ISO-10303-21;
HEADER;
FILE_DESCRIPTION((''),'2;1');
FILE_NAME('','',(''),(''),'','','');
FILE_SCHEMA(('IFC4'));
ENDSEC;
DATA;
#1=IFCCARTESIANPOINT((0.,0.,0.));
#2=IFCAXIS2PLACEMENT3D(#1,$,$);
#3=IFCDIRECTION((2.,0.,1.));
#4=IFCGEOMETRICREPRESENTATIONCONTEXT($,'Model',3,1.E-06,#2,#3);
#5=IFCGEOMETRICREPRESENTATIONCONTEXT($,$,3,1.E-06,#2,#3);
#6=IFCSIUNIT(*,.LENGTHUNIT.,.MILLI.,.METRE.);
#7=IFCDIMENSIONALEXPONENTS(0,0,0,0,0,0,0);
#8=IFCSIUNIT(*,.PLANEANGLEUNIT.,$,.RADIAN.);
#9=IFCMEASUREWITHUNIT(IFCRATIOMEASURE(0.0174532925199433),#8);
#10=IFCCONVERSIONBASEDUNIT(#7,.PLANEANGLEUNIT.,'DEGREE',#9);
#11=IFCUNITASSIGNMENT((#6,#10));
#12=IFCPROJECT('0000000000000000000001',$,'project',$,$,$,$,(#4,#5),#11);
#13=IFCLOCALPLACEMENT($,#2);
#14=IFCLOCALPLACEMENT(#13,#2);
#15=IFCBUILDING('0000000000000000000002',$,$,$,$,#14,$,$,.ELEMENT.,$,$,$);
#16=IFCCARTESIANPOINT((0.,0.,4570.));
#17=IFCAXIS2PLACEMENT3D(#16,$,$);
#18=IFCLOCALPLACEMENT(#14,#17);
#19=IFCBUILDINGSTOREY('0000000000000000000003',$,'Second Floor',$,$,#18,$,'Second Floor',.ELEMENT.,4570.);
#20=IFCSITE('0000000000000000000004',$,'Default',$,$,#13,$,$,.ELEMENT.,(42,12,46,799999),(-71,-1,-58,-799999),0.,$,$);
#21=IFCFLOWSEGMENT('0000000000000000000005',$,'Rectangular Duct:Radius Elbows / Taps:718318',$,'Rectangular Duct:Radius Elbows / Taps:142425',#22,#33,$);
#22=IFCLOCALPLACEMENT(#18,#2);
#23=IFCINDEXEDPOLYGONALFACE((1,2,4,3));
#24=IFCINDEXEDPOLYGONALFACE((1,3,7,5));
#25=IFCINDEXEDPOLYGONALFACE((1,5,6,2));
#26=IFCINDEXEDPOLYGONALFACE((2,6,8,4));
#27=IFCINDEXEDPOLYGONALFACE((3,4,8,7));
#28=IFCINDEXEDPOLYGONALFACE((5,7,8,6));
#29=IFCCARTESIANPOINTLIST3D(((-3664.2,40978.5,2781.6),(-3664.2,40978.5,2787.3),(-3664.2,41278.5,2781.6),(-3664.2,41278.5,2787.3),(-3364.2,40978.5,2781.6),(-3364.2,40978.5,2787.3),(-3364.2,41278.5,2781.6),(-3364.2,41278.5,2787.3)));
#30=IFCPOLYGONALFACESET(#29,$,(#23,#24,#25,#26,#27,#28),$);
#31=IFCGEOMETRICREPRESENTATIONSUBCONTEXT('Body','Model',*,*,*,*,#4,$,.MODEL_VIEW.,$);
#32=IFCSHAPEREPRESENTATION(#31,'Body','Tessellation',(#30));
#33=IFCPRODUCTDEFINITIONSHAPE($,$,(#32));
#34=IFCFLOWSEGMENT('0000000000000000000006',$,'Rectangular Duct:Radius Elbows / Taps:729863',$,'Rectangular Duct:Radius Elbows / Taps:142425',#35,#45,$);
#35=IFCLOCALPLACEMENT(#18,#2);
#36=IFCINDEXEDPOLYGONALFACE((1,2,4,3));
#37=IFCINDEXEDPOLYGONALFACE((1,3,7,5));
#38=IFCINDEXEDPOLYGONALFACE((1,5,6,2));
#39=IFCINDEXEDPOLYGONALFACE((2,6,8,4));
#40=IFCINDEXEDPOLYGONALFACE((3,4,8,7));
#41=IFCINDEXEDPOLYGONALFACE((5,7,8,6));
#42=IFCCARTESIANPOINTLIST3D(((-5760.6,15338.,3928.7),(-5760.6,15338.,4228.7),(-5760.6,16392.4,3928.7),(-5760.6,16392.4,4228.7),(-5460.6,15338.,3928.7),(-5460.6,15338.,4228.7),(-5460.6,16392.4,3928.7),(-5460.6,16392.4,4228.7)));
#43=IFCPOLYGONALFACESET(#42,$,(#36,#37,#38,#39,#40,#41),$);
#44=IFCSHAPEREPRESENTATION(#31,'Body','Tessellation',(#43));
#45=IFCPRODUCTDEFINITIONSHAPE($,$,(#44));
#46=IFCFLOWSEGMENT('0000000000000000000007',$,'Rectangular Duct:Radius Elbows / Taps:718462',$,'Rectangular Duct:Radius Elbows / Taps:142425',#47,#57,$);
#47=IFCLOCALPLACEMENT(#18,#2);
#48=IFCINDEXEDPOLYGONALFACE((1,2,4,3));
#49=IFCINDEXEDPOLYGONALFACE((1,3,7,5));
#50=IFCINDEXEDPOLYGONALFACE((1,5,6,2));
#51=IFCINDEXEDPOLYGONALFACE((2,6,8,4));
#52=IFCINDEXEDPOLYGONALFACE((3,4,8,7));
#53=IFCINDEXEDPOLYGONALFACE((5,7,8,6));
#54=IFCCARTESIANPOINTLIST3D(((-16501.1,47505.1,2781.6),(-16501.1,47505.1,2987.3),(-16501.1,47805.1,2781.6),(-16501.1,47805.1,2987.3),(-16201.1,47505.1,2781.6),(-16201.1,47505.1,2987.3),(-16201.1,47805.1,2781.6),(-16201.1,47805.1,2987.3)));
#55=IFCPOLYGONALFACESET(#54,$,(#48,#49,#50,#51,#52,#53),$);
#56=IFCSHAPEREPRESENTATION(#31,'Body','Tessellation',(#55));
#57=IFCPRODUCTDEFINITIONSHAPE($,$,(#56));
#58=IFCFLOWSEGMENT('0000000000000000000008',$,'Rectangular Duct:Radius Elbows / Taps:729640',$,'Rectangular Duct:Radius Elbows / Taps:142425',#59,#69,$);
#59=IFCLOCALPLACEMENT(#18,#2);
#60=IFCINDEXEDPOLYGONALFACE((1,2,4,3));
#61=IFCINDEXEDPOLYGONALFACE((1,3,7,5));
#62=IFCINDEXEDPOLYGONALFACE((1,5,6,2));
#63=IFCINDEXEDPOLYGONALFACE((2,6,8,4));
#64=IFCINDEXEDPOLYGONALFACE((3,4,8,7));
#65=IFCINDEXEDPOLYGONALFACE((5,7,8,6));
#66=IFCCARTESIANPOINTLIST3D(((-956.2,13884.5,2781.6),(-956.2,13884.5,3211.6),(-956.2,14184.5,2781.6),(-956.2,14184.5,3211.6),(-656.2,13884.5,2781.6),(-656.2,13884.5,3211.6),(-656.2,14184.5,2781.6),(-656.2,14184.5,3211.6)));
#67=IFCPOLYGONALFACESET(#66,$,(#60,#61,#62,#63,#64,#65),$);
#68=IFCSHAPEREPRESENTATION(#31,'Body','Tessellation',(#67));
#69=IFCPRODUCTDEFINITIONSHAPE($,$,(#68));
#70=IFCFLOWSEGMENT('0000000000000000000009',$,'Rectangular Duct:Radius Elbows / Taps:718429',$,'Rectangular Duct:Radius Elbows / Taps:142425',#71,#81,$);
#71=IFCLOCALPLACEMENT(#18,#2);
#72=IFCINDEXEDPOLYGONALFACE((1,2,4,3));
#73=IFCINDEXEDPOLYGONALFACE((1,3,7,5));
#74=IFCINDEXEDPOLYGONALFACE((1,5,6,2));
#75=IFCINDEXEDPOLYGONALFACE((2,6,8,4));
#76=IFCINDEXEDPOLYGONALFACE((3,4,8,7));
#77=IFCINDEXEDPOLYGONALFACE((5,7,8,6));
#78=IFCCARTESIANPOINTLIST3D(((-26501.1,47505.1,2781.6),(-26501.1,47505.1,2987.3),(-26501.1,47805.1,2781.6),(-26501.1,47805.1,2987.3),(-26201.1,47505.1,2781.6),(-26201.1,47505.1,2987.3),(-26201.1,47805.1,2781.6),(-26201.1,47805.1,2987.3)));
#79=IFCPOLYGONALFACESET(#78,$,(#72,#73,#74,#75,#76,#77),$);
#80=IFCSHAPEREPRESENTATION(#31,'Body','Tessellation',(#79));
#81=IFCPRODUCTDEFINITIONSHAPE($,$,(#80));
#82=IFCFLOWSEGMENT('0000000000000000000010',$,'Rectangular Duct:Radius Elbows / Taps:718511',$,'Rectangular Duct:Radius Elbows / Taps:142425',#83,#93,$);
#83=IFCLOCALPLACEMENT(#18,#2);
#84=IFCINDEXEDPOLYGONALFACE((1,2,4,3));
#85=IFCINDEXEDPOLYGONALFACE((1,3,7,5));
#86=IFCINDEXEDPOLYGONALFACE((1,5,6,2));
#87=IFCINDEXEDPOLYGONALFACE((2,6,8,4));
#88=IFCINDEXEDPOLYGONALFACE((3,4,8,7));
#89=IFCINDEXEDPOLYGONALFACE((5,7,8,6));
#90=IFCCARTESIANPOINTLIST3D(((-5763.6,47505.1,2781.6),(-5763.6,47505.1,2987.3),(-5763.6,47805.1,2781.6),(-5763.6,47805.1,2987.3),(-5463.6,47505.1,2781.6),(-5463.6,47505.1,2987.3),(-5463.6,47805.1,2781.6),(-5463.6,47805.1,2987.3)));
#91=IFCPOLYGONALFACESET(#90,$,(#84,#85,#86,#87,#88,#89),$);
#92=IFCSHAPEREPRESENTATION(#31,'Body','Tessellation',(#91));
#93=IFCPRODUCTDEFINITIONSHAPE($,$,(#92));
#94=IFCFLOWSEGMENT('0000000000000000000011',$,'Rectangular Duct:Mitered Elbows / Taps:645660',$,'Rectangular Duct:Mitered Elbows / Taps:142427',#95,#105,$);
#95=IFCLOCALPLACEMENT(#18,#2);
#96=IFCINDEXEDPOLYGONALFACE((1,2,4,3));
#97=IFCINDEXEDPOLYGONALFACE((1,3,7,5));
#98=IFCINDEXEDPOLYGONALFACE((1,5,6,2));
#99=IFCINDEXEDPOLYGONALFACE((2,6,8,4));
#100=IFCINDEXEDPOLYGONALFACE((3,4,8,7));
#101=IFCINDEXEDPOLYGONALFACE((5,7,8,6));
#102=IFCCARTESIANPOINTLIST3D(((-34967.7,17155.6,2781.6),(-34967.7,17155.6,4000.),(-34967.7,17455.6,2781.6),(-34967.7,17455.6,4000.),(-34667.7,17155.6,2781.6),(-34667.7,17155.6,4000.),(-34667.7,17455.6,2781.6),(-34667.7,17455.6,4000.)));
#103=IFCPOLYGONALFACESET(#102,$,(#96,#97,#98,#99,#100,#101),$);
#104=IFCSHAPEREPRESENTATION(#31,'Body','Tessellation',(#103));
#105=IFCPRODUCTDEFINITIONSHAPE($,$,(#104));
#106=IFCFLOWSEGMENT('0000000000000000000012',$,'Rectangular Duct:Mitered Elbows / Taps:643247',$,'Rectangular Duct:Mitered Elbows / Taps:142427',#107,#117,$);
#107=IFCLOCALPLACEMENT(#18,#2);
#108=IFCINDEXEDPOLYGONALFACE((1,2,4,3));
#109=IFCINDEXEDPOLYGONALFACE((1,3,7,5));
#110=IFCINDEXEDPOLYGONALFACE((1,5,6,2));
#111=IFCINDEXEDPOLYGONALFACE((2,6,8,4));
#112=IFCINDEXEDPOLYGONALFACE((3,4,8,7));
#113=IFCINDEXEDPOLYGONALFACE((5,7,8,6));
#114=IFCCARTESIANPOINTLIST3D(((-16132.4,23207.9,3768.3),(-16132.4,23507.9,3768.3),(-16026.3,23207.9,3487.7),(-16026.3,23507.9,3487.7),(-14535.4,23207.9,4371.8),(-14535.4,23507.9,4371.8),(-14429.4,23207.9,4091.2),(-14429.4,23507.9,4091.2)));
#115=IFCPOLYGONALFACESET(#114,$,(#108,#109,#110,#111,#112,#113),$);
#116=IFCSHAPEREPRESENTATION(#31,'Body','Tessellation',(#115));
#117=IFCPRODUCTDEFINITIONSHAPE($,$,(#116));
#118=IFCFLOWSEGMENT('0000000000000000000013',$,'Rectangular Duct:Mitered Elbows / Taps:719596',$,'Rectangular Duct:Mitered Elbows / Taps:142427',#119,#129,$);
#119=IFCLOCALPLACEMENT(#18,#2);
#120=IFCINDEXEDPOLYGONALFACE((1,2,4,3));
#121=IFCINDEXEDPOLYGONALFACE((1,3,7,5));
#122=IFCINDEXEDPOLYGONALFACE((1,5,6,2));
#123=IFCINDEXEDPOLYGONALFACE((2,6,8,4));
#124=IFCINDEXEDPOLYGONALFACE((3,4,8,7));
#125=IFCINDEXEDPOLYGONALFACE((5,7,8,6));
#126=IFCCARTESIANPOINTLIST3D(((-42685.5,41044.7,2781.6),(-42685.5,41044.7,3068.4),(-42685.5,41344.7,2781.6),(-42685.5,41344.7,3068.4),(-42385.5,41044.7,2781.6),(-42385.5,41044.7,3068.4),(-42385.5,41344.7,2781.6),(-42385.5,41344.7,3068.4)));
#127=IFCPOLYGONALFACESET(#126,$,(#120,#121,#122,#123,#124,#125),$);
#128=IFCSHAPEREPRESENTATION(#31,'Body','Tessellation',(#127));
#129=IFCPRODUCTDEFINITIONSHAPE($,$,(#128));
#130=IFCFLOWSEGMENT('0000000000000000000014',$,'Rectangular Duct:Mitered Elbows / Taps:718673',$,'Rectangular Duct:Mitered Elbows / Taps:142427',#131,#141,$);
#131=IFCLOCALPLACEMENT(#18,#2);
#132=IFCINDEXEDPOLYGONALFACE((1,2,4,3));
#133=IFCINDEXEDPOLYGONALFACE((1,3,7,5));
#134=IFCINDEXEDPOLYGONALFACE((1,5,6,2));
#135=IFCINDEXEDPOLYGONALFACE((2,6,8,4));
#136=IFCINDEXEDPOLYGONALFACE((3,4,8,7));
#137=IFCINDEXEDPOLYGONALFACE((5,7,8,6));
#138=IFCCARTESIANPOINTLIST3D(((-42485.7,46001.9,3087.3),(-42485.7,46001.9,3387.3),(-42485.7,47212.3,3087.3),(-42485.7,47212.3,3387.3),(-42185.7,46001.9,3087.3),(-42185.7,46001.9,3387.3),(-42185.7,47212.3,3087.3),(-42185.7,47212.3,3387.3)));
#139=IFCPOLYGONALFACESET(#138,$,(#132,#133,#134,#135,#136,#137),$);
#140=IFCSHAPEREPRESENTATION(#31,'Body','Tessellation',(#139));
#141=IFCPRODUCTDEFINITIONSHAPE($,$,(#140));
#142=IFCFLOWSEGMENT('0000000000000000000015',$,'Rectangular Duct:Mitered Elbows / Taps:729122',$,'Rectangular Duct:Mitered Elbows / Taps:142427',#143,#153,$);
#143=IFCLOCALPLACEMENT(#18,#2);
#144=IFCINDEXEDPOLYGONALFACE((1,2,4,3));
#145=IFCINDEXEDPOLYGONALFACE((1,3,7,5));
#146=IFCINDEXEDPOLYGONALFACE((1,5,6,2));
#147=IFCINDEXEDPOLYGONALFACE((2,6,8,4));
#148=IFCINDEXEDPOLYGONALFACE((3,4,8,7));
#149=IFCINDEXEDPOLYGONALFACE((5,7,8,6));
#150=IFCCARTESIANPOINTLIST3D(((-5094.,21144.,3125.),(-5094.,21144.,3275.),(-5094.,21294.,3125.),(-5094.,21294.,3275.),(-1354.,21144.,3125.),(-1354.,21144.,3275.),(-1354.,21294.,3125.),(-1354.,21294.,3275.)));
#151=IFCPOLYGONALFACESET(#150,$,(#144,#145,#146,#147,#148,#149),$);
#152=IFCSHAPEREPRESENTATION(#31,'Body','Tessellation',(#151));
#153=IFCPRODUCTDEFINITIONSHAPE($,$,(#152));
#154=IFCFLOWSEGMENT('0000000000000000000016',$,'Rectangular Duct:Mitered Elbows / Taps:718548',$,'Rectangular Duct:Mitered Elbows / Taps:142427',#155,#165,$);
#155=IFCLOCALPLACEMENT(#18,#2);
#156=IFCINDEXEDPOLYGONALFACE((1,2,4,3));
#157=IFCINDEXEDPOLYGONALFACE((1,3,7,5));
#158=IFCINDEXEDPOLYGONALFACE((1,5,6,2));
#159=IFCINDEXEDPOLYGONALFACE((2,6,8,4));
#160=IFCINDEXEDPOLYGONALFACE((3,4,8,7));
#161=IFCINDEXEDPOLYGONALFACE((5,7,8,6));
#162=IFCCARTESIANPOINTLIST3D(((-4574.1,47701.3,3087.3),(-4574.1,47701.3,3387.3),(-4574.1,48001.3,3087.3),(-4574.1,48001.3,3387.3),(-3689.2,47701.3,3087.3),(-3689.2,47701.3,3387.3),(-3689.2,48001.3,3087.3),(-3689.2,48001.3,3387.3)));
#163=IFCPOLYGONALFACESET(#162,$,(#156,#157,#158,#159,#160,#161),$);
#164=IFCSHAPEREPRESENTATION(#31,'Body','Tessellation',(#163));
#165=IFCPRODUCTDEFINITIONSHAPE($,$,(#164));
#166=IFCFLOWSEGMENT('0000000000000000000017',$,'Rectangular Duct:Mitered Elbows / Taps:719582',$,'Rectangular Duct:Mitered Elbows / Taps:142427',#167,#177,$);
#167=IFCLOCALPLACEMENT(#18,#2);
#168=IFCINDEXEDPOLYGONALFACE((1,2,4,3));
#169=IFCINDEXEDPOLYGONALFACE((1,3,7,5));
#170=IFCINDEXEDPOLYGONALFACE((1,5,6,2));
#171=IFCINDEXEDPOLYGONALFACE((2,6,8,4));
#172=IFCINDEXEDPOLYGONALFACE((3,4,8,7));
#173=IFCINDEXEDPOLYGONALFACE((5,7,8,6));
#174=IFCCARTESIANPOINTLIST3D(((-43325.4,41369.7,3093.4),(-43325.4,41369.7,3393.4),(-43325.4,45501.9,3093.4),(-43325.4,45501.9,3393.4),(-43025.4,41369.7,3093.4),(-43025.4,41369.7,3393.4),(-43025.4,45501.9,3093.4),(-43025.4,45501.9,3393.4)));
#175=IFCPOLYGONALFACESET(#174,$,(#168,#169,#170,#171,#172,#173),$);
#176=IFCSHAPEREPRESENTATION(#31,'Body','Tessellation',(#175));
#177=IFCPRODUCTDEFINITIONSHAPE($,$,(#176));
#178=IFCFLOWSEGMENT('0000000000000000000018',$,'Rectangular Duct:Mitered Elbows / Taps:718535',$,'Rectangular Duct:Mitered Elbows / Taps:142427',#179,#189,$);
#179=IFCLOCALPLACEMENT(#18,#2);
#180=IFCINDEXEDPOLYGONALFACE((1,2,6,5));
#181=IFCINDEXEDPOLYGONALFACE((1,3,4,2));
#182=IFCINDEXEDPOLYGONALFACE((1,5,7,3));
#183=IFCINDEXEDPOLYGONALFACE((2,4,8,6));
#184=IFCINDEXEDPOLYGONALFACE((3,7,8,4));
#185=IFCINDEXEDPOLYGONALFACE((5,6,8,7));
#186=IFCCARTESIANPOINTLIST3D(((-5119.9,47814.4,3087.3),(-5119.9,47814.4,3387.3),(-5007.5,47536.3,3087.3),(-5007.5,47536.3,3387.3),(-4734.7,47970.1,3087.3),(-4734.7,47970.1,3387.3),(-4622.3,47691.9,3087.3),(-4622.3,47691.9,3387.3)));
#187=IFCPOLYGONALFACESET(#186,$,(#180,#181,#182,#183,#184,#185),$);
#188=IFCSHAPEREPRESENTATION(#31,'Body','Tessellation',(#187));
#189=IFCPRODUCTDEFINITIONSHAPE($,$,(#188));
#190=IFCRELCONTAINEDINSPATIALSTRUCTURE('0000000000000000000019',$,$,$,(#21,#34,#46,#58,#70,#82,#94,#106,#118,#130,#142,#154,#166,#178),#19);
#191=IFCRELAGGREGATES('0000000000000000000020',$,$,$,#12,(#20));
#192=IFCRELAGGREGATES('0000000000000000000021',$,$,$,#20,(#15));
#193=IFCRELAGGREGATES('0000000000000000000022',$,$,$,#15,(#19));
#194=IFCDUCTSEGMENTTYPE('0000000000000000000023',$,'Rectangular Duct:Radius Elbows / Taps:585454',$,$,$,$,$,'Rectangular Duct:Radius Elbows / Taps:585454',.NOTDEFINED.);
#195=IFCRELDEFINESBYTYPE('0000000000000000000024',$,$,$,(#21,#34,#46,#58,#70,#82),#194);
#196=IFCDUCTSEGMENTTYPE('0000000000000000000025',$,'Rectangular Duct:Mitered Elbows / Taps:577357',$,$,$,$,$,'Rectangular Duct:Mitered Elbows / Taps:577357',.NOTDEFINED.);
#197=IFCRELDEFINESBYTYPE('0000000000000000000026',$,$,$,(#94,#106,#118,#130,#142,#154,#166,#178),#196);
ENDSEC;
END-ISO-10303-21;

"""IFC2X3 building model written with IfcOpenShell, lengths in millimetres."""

from ifc_helpers import new_model, entity, si_unit, converted_unit, direction, frame, frame_2d, origin, origin_2d_with_axis, place, context, subcontext, project, spatial, rectangle, extrude, type_object, element, save


model = new_model("IFC2X3")

# Units and contexts
model_context = context("Model", 3, precision=1e-06, world=origin(), true_north=direction((2.0, 0.0, 1.0)))
context_of_model = context(None, 3, precision=1e-06, world=origin(), true_north=direction((2.0, 0.0, 1.0)))
body_context = subcontext(model_context, "Body", "Model", "MODEL_VIEW")
ifc_project = project(units=[si_unit("LENGTHUNIT", "METRE", prefix="MILLI"), converted_unit("PLANEANGLEUNIT", "DEGREE", entity("IfcRatioMeasure", 0.0174532925199433), si_unit("PLANEANGLEUNIT", "RADIAN"), dimensions=[0, 0, 0, 0, 0, 0, 0])], contexts=[model_context, context_of_model])

# Site, building, storey
site_placement = place(None, origin())
site = spatial("IfcSite", under=ifc_project, at=site_placement, Name="Default", CompositionType="ELEMENT", RefLatitude=(42, 12, 46, 799999), RefLongitude=(-71, -1, -58, -799999), RefElevation=0.0)
building_placement = place(site_placement, origin())
building = spatial("IfcBuilding", under=site, at=building_placement, CompositionType="ELEMENT")
storey_placement = place(building_placement, frame((0.0, 0.0, 4570.0)))
storey = spatial("IfcBuildingStorey", under=building, at=storey_placement, Name="Second Floor", LongName="Second Floor", CompositionType="ELEMENT", Elevation=4570.0)

# Flow segments
duct_segment_type_1 = type_object("IfcDuctSegmentType", Name="Rectangular Duct:Radius Elbows / Taps:585454", ElementType="Rectangular Duct:Radius Elbows / Taps:585454", PredefinedType="NOTDEFINED")
flow_segment_1_placement = place(storey_placement, origin())
element("IfcFlowSegment", 1, at=flow_segment_1_placement, inside=storey, type_object=duct_segment_type_1, Name="Rectangular Duct:Radius Elbows / Taps:718318", ObjectType="Rectangular Duct:Radius Elbows / Taps:142425", context=body_context, shape_type="SweptSolid", body=[
    extrude(rectangle(XDim=300.0, YDim=300.0, at=origin_2d_with_axis()), frame((-3514.2, 41128.5, 2781.6)), (0.0, 0.0, 1.0), 5.7),
])
flow_segment_2_placement = place(storey_placement, origin())
element("IfcFlowSegment", 2, at=flow_segment_2_placement, inside=storey, type_object=duct_segment_type_1, Name="Rectangular Duct:Radius Elbows / Taps:729863", ObjectType="Rectangular Duct:Radius Elbows / Taps:142425", context=body_context, shape_type="SweptSolid", body=[
    extrude(rectangle(XDim=1054.5, YDim=300.0, at=frame_2d((0.0, 0.0), x_axis=(1.0, 0.0))), frame((-5610.6, 15865.2, 3928.7), z_axis=(0.0, 0.0, 1.0), x_axis=(0.0, 1.0, 0.0)), (0.0, 0.0, 1.0), 300.0),
])
flow_segment_3_placement = place(storey_placement, origin())
element("IfcFlowSegment", 3, at=flow_segment_3_placement, inside=storey, type_object=duct_segment_type_1, Name="Rectangular Duct:Radius Elbows / Taps:718462", ObjectType="Rectangular Duct:Radius Elbows / Taps:142425", context=body_context, shape_type="SweptSolid", body=[
    extrude(rectangle(XDim=300.0, YDim=300.0, at=origin_2d_with_axis()), frame((-16351.1, 47655.1, 2781.6), z_axis=(0.0, 0.0, 1.0), x_axis=(-1.0, 0.0, 0.0)), (0.0, 0.0, 1.0), 205.7),
])
flow_segment_4_placement = place(storey_placement, origin())
element("IfcFlowSegment", 4, at=flow_segment_4_placement, inside=storey, type_object=duct_segment_type_1, Name="Rectangular Duct:Radius Elbows / Taps:729640", ObjectType="Rectangular Duct:Radius Elbows / Taps:142425", context=body_context, shape_type="SweptSolid", body=[
    extrude(rectangle(XDim=300.0, YDim=300.0, at=frame_2d((0.0, 0.0), x_axis=(1.0, 0.0))), frame((-806.2, 14034.5, 2781.6), z_axis=(0.0, 0.0, 1.0), x_axis=(0.0, -1.0, 0.0)), (0.0, 0.0, 1.0), 430.0),
])
flow_segment_5_placement = place(storey_placement, origin())
element("IfcFlowSegment", 5, at=flow_segment_5_placement, inside=storey, type_object=duct_segment_type_1, Name="Rectangular Duct:Radius Elbows / Taps:718429", ObjectType="Rectangular Duct:Radius Elbows / Taps:142425", context=body_context, shape_type="SweptSolid", body=[
    extrude(rectangle(XDim=300.0, YDim=300.0, at=origin_2d_with_axis()), frame((-26351.1, 47655.1, 2781.6), z_axis=(0.0, 0.0, 1.0), x_axis=(-1.0, 0.0, 0.0)), (0.0, 0.0, 1.0), 205.7),
])
flow_segment_6_placement = place(storey_placement, origin())
element("IfcFlowSegment", 6, at=flow_segment_6_placement, inside=storey, type_object=duct_segment_type_1, Name="Rectangular Duct:Radius Elbows / Taps:718511", ObjectType="Rectangular Duct:Radius Elbows / Taps:142425", context=body_context, shape_type="SweptSolid", body=[
    extrude(rectangle(XDim=300.0, YDim=300.0, at=frame_2d((0.0, 0.0), x_axis=(1.0, 0.0))), frame((-5613.6, 47655.1, 2781.6), z_axis=(0.0, 0.0, 1.0), x_axis=(-1.0, 0.0, 0.0)), (0.0, 0.0, 1.0), 205.7),
])
duct_segment_type_2 = type_object("IfcDuctSegmentType", Name="Rectangular Duct:Mitered Elbows / Taps:577357", ElementType="Rectangular Duct:Mitered Elbows / Taps:577357", PredefinedType="NOTDEFINED")
flow_segment_7_placement = place(storey_placement, origin())
element("IfcFlowSegment", 7, at=flow_segment_7_placement, inside=storey, type_object=duct_segment_type_2, Name="Rectangular Duct:Mitered Elbows / Taps:645660", ObjectType="Rectangular Duct:Mitered Elbows / Taps:142427", context=body_context, shape_type="SweptSolid", body=[
    extrude(rectangle(XDim=300.0, YDim=300.0, at=frame_2d((0.0, 0.0), x_axis=(1.0, 0.0))), frame((-34817.7, 17305.6, 2781.6), z_axis=(0.0, 0.0, 1.0), x_axis=(-1.0, 0.0, 0.0)), (0.0, 0.0, 1.0), 1218.4),
])
flow_segment_8_placement = place(storey_placement, origin())
element("IfcFlowSegment", 8, at=flow_segment_8_placement, inside=storey, type_object=duct_segment_type_2, Name="Rectangular Duct:Mitered Elbows / Taps:643247", ObjectType="Rectangular Duct:Mitered Elbows / Taps:142427", context=body_context, shape_type="SweptSolid", body=[
    extrude(rectangle(XDim=300.0, YDim=300.0, at=frame_2d((0.0, 0.0), x_axis=(1.0, 0.0))), frame((-16079.4, 23357.9, 3628.0), z_axis=(0.935442, 0.0, 0.353481), x_axis=(-0.353481, 0.0, 0.935442)), (0.0, 0.0, 1.0), 1707.2),
])
flow_segment_9_placement = place(storey_placement, origin())
element("IfcFlowSegment", 9, at=flow_segment_9_placement, inside=storey, type_object=duct_segment_type_2, Name="Rectangular Duct:Mitered Elbows / Taps:719596", ObjectType="Rectangular Duct:Mitered Elbows / Taps:142427", context=body_context, shape_type="SweptSolid", body=[
    extrude(rectangle(XDim=300.0, YDim=300.0, at=origin_2d_with_axis()), frame((-42535.5, 41194.7, 2781.6)), (0.0, 0.0, 1.0), 286.8),
])
flow_segment_10_placement = place(storey_placement, origin())
element("IfcFlowSegment", 10, at=flow_segment_10_placement, inside=storey, type_object=duct_segment_type_2, Name="Rectangular Duct:Mitered Elbows / Taps:718673", ObjectType="Rectangular Duct:Mitered Elbows / Taps:142427", context=body_context, shape_type="SweptSolid", body=[
    extrude(rectangle(XDim=1210.4, YDim=300.0, at=origin_2d_with_axis()), frame((-42335.7, 46607.1, 3087.3), z_axis=(0.0, 0.0, 1.0), x_axis=(0.0, -1.0, 0.0)), (0.0, 0.0, 1.0), 300.0),
])
flow_segment_11_placement = place(storey_placement, origin())
element("IfcFlowSegment", 11, at=flow_segment_11_placement, inside=storey, type_object=duct_segment_type_2, Name="Rectangular Duct:Mitered Elbows / Taps:729122", ObjectType="Rectangular Duct:Mitered Elbows / Taps:142427", context=body_context, shape_type="SweptSolid", body=[
    extrude(rectangle(XDim=3740.0, YDim=150.0, at=frame_2d((0.0, 0.0), x_axis=(1.0, 0.0))), frame((-3224.0, 21219.0, 3125.0), z_axis=(0.0, 0.0, 1.0), x_axis=(-1.0, 0.0, 0.0)), (0.0, 0.0, 1.0), 150.0),
])
flow_segment_12_placement = place(storey_placement, origin())
element("IfcFlowSegment", 12, at=flow_segment_12_placement, inside=storey, type_object=duct_segment_type_2, Name="Rectangular Duct:Mitered Elbows / Taps:718548", ObjectType="Rectangular Duct:Mitered Elbows / Taps:142427", context=body_context, shape_type="SweptSolid", body=[
    extrude(rectangle(XDim=885.0, YDim=300.0, at=origin_2d_with_axis()), frame((-4131.7, 47851.3, 3087.3), z_axis=(0.0, 0.0, 1.0), x_axis=(-1.0, 0.0, 0.0)), (0.0, 0.0, 1.0), 300.0),
])
flow_segment_13_placement = place(storey_placement, origin())
element("IfcFlowSegment", 13, at=flow_segment_13_placement, inside=storey, type_object=duct_segment_type_2, Name="Rectangular Duct:Mitered Elbows / Taps:719582", ObjectType="Rectangular Duct:Mitered Elbows / Taps:142427", context=body_context, shape_type="SweptSolid", body=[
    extrude(rectangle(XDim=4132.2, YDim=300.0, at=origin_2d_with_axis()), frame((-43175.4, 43435.8, 3093.4), z_axis=(0.0, 0.0, 1.0), x_axis=(0.0, -1.0, 0.0)), (0.0, 0.0, 1.0), 300.0),
])
flow_segment_14_placement = place(storey_placement, origin())
element("IfcFlowSegment", 14, at=flow_segment_14_placement, inside=storey, type_object=duct_segment_type_2, Name="Rectangular Duct:Mitered Elbows / Taps:718535", ObjectType="Rectangular Duct:Mitered Elbows / Taps:142427", context=body_context, shape_type="SweptSolid", body=[
    extrude(rectangle(XDim=415.4, YDim=300.0, at=origin_2d_with_axis()), frame((-4871.1, 47753.2, 3087.3), z_axis=(0.0, 0.0, 1.0), x_axis=(0.927184, 0.374607, 0.0)), (0.0, 0.0, 1.0), 300.0),
])

save(model, "model.ifc")
